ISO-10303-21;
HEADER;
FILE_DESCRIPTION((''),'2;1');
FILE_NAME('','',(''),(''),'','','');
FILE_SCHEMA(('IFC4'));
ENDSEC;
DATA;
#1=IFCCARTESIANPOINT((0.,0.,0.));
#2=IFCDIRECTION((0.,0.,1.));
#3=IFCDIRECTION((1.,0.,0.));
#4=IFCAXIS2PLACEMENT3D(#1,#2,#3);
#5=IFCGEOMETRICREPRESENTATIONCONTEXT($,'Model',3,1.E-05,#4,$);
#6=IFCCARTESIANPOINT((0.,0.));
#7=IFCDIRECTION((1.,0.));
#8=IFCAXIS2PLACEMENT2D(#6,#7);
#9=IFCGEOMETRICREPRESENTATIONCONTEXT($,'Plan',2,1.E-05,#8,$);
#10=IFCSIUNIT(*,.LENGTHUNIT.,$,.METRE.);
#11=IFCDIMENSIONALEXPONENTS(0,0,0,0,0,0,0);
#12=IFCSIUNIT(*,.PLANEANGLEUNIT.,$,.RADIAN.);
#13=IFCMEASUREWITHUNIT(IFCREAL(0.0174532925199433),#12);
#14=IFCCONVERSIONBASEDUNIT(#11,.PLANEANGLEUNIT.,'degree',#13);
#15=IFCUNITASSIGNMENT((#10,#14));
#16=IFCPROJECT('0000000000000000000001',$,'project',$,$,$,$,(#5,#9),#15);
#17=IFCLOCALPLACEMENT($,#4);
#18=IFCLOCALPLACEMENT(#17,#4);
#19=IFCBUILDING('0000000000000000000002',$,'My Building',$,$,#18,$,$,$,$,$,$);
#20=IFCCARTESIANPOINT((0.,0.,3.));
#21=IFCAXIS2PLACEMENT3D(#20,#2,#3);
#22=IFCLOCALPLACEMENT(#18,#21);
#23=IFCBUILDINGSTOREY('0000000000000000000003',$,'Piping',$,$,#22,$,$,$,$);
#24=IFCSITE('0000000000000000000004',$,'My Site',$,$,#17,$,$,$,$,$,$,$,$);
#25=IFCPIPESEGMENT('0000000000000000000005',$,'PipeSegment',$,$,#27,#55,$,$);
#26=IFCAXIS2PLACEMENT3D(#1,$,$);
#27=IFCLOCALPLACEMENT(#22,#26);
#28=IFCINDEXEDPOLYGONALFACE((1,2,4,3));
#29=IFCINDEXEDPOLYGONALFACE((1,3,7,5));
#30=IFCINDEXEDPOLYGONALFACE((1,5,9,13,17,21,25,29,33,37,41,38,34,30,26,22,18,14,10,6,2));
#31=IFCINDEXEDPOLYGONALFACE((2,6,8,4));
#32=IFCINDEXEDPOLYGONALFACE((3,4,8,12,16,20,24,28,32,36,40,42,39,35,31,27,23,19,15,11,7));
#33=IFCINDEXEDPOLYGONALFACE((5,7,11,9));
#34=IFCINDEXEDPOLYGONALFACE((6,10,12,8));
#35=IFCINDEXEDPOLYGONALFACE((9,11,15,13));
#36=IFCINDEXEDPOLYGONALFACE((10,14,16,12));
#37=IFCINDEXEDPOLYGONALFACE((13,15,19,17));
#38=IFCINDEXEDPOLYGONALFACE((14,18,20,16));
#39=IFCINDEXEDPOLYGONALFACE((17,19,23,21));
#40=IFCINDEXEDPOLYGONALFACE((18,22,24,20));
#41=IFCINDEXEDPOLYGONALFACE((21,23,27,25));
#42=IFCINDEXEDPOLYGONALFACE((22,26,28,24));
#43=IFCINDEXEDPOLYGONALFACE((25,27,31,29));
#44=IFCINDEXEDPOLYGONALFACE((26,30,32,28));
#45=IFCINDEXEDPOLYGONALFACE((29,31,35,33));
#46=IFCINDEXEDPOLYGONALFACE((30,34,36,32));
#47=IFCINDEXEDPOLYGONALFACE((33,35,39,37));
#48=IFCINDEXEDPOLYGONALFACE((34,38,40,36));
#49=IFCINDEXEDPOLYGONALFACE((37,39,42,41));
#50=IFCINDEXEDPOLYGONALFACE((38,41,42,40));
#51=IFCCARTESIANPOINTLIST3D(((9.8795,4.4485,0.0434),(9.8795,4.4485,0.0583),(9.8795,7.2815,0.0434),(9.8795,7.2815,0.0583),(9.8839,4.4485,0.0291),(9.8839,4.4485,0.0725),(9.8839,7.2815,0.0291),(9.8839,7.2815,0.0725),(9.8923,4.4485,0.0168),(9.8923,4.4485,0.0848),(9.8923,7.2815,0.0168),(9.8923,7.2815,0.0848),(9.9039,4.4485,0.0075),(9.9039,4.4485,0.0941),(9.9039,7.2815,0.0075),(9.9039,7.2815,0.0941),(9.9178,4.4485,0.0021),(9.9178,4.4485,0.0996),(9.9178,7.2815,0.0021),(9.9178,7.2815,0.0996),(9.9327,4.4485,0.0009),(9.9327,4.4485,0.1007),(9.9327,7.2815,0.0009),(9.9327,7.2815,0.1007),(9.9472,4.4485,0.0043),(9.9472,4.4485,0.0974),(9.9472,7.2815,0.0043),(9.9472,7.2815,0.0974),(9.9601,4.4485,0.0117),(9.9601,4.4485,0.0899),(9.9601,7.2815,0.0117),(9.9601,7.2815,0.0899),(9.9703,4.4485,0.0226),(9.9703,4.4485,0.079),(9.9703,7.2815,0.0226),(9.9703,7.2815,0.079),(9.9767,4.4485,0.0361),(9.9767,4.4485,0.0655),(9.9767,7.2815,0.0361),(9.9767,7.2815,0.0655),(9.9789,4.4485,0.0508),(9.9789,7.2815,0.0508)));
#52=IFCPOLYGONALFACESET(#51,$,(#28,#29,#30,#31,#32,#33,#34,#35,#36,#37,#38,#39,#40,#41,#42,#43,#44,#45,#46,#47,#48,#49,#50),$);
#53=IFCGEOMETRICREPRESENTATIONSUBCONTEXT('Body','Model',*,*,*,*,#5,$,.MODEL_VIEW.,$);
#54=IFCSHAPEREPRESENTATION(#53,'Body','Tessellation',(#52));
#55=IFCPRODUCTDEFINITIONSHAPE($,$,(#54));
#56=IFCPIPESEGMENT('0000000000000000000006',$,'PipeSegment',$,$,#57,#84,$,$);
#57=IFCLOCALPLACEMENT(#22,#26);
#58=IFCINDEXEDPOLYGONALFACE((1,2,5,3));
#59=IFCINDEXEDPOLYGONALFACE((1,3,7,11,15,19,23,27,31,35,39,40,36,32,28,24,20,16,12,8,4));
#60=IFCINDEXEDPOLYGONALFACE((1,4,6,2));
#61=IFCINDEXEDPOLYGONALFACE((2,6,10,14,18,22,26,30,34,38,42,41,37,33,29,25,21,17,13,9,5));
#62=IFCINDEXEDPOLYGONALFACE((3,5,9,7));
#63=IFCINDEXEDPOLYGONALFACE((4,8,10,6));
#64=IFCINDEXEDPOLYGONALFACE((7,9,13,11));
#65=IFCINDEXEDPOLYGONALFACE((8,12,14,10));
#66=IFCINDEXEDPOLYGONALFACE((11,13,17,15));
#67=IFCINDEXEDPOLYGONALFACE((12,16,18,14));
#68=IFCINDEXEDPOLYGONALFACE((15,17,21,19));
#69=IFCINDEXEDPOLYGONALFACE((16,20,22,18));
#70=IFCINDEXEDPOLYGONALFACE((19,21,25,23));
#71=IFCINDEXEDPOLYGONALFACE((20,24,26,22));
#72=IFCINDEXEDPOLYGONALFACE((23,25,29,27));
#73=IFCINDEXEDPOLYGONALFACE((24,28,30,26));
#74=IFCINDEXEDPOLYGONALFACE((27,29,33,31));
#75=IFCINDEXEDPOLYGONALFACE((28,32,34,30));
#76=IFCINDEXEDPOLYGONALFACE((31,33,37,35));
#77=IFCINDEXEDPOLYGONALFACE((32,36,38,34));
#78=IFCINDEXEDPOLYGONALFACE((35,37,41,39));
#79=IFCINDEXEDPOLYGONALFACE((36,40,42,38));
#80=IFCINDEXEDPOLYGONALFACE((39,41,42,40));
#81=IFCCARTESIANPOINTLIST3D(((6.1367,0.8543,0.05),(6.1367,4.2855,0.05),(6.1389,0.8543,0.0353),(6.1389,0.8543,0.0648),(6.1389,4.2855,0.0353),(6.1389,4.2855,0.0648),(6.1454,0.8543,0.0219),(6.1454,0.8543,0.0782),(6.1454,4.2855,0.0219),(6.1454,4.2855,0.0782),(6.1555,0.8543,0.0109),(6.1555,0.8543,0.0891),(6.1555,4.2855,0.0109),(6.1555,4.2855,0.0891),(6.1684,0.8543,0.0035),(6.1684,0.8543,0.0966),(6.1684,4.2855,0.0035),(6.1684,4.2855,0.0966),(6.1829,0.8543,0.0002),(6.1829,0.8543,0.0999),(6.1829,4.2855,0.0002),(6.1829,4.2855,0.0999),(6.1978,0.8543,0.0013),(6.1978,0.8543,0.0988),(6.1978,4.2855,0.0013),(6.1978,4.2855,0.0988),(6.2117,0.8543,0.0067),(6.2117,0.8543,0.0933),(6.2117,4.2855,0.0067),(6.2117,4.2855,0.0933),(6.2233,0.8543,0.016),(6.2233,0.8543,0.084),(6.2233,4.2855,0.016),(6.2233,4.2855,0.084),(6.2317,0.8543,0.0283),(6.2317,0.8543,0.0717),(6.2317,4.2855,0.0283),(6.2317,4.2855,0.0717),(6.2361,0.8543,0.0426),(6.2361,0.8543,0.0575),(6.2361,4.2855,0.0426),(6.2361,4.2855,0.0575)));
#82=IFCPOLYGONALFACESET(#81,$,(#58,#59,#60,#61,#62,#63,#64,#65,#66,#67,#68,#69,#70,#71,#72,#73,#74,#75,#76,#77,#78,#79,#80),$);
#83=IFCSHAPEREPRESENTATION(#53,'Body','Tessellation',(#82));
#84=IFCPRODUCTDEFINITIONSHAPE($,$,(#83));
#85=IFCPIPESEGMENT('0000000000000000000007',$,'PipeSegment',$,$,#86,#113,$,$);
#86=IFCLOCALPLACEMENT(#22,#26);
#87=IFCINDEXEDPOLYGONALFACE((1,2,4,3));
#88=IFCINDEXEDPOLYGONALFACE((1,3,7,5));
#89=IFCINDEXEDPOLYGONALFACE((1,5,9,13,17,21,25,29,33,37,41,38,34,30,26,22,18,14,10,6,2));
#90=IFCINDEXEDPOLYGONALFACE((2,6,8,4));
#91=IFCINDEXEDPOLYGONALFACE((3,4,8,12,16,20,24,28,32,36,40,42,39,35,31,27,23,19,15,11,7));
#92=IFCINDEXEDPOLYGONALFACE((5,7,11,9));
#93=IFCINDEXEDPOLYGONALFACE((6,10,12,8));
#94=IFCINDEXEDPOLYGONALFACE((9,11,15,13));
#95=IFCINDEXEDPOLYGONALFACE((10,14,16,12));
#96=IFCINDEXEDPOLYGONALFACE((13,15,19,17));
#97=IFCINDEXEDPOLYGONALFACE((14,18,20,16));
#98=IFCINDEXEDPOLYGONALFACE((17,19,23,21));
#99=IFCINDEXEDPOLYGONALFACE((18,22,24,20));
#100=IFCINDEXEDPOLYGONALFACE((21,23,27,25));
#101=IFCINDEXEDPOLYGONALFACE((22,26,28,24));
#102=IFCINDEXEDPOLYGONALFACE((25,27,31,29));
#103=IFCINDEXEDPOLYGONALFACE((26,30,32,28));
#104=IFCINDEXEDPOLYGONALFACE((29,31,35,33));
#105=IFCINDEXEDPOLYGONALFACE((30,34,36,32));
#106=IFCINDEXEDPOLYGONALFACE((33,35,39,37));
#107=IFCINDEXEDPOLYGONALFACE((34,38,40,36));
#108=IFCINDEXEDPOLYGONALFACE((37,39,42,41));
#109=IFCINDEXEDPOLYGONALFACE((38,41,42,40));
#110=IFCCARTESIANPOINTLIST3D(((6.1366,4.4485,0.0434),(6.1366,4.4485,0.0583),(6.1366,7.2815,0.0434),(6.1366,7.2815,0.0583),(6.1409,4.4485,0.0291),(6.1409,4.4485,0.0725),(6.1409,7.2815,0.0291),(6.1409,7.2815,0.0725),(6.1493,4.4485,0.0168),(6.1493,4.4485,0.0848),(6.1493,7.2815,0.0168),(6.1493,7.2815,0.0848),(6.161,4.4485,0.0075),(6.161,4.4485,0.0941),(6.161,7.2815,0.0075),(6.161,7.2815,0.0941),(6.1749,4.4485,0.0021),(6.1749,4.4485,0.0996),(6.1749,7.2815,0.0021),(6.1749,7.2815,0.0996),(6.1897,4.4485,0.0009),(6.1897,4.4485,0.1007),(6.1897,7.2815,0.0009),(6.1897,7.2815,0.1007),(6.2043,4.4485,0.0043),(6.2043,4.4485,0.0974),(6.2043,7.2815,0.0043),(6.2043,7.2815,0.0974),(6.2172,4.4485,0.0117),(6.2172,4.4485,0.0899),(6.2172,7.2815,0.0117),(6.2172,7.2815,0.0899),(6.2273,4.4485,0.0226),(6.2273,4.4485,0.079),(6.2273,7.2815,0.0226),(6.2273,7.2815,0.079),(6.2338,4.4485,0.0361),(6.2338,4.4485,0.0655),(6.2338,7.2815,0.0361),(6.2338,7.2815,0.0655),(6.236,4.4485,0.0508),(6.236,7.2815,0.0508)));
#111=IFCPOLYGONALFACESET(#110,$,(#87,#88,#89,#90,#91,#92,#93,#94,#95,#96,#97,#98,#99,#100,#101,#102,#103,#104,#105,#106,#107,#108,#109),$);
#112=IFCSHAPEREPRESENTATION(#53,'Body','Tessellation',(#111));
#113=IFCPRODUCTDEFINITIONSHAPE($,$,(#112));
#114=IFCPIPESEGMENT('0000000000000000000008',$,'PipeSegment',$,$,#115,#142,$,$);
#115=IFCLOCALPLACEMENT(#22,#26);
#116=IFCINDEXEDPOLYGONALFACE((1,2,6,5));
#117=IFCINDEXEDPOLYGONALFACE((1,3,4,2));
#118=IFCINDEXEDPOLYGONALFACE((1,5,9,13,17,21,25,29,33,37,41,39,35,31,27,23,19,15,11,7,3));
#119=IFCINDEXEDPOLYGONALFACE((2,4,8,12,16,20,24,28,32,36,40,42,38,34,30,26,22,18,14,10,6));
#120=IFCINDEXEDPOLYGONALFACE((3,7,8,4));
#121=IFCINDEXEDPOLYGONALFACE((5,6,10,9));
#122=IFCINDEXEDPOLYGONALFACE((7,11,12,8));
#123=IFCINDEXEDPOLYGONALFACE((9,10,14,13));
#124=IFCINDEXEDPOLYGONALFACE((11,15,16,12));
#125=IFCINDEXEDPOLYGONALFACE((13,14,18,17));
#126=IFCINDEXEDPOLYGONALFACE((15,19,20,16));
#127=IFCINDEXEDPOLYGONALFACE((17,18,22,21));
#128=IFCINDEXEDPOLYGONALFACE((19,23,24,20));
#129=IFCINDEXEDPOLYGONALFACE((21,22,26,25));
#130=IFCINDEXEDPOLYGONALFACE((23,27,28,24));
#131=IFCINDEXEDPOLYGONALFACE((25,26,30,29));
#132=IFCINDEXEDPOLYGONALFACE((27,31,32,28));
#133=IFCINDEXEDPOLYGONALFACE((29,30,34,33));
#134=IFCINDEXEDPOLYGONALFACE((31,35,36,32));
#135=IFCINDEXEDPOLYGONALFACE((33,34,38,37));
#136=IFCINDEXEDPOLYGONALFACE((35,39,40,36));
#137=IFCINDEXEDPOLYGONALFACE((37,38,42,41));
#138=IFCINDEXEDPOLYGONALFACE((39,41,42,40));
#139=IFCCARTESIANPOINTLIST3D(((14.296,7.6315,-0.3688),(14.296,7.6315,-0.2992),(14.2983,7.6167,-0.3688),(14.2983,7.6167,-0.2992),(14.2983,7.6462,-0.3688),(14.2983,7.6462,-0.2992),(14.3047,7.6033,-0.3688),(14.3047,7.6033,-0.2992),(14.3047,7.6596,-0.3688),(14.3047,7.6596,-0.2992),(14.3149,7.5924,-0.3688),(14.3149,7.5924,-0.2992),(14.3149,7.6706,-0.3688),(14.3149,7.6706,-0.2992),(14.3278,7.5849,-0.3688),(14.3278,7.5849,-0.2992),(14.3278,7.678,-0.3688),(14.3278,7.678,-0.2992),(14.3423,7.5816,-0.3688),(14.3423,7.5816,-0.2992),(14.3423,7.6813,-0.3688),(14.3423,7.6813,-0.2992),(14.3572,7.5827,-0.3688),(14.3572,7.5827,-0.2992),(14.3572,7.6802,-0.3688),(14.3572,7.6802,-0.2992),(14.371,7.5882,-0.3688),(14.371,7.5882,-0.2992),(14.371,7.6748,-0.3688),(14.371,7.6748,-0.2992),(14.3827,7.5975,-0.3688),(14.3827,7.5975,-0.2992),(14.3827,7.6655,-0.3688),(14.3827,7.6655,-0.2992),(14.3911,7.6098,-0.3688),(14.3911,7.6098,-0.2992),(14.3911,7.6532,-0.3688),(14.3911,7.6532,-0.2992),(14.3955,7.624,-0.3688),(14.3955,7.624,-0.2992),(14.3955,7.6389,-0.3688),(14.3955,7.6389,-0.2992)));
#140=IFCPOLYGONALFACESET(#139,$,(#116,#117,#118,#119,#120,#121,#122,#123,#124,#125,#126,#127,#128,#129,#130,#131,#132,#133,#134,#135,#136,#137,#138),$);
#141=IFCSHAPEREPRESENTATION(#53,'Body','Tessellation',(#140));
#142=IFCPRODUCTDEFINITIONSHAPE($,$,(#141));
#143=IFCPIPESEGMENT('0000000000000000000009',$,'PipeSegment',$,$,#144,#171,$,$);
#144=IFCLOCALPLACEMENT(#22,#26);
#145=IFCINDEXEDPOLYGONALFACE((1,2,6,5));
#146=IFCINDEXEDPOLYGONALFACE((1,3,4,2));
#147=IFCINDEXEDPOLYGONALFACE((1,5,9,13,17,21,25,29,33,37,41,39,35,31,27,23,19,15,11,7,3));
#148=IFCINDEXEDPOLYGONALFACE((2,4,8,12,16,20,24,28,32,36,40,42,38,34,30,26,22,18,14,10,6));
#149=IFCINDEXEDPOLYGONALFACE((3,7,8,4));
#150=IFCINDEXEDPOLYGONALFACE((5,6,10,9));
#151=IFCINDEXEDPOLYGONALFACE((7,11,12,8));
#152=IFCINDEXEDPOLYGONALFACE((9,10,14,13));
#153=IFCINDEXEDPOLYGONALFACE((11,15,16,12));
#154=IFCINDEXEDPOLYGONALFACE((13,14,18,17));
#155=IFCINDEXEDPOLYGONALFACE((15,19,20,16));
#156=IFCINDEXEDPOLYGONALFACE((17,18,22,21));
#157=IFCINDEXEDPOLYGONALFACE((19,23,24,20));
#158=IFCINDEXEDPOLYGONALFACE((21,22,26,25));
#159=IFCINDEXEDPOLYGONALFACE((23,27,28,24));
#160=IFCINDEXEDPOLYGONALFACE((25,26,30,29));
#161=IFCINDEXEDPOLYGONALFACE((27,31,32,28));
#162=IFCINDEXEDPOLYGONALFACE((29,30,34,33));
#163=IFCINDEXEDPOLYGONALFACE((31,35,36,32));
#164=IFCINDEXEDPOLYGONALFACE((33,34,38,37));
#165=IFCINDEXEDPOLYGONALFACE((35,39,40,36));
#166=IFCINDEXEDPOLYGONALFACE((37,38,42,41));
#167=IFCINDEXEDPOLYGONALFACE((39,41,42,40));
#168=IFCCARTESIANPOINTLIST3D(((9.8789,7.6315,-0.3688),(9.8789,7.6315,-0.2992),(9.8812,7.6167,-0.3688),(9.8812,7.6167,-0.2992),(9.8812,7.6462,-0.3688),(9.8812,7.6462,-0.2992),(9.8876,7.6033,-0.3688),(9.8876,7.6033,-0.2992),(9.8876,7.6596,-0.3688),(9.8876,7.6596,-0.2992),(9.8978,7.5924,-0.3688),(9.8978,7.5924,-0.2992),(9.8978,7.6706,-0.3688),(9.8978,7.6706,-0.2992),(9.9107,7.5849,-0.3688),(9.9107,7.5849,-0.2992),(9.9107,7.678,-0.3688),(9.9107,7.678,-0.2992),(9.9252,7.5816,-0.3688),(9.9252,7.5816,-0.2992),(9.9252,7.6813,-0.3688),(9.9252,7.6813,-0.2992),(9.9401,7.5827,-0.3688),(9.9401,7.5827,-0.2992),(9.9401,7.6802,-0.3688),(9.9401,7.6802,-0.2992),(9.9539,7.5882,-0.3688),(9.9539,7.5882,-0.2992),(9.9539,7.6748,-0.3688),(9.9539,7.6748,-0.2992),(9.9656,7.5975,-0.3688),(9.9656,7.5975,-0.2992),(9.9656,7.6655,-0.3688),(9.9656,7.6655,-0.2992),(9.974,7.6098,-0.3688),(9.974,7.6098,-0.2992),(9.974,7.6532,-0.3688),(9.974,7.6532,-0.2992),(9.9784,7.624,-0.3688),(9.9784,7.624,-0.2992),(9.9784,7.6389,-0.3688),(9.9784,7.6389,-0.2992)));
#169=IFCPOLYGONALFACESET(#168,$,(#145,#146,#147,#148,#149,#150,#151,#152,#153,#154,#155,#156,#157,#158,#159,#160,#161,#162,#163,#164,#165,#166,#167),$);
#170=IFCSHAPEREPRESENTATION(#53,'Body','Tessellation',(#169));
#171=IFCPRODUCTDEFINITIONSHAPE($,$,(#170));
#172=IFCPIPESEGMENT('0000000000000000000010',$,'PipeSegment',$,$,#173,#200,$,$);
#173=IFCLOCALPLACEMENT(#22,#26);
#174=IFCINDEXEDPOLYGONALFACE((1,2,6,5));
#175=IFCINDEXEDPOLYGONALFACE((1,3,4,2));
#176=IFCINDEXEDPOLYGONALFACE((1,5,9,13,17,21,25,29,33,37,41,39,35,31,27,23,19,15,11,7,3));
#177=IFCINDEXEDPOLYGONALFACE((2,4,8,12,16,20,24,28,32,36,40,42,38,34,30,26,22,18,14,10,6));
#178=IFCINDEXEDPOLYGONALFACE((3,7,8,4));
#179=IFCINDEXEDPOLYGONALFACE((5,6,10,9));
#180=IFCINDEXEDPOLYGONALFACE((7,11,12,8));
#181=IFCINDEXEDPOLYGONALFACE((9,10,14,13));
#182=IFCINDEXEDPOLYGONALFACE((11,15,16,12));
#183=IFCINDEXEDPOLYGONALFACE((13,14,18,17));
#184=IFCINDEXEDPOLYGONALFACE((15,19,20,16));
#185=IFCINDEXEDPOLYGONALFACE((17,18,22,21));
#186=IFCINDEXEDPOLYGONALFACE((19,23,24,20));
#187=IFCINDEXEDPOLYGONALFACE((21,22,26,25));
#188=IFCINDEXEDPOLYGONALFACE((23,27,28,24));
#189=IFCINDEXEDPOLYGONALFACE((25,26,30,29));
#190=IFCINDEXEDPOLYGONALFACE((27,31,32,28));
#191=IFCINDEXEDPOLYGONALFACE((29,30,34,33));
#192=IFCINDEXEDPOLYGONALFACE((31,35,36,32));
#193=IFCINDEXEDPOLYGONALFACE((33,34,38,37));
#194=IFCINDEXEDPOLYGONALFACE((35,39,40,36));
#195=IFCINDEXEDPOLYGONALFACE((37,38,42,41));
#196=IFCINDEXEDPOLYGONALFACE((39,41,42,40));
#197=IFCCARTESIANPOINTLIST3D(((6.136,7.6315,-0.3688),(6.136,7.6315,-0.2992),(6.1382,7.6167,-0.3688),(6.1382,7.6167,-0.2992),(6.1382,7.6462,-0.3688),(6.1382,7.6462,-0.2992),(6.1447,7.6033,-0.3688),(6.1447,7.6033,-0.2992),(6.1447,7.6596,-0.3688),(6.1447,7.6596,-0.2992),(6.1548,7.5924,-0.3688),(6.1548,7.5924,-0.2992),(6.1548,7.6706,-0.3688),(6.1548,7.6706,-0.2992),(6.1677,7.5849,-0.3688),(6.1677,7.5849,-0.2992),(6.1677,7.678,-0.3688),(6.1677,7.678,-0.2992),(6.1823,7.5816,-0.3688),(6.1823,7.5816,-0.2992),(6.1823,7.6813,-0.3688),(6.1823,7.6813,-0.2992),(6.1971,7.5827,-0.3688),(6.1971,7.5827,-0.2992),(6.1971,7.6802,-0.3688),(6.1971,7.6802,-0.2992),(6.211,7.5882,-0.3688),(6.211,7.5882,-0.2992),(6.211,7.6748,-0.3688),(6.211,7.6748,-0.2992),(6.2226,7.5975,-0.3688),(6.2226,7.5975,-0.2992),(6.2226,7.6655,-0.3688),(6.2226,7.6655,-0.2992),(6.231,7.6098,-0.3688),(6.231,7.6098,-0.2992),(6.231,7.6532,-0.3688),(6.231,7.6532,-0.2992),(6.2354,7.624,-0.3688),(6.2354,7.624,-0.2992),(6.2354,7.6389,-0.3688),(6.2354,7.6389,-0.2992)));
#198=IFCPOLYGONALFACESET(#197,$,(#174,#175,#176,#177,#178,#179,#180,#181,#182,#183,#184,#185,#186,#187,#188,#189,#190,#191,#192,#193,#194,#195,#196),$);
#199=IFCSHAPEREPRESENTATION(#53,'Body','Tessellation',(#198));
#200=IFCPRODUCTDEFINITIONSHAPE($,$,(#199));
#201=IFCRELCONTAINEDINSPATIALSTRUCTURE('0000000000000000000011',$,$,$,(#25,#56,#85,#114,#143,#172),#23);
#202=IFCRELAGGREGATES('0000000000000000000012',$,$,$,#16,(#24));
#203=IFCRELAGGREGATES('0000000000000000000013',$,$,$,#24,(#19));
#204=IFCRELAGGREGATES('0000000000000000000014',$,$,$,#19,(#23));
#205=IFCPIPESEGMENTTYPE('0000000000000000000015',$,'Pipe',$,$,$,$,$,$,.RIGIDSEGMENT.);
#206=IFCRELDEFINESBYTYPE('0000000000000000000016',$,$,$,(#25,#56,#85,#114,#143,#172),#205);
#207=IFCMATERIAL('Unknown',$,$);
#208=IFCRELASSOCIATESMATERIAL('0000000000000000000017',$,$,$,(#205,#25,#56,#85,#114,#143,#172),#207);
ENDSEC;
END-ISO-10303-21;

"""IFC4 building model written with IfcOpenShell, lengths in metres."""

from ifc_helpers import new_model, entity, si_unit, converted_unit, frame, origin_with_axes, origin_2d_with_axis, place, context, subcontext, project, spatial, circle, extrude, material, material_profile, profile_set, profile_usage, type_object, element, save


model = new_model("IFC4")

# Units and contexts
model_context = context("Model", 3, precision=1e-05, world=origin_with_axes())
plan_context = context("Plan", 2, precision=1e-05, world=origin_2d_with_axis())
body_context = subcontext(model_context, "Body", "Model", "MODEL_VIEW")
ifc_project = project(units=[si_unit("LENGTHUNIT", "METRE"), converted_unit("PLANEANGLEUNIT", "degree", entity("IfcReal", 0.0174532925199433), si_unit("PLANEANGLEUNIT", "RADIAN"), dimensions=[0, 0, 0, 0, 0, 0, 0])], contexts=[model_context, plan_context])

# Site, building, storey
site_placement = place(None, origin_with_axes())
site = spatial("IfcSite", under=ifc_project, at=site_placement, Name="My Site")
building_placement = place(site_placement, origin_with_axes())
building = spatial("IfcBuilding", under=site, at=building_placement, Name="My Building")
storey_placement = place(building_placement, frame((0.0, 0.0, 3.0), z_axis=(0.0, 0.0, 1.0), x_axis=(1.0, 0.0, 0.0)))
storey = spatial("IfcBuildingStorey", under=building, at=storey_placement, Name="Piping")

# Pipe segments
ifc_material = material(Name="Unknown")
ifc_material_profile_1 = material_profile(ifc_material, circle(Radius=0.05))
ifc_profile_set_1 = profile_set([ifc_material_profile_1])
pipe_segment_type = type_object("IfcPipeSegmentType", Name="Pipe", PredefinedType="RIGIDSEGMENT", material=ifc_profile_set_1)
ifc_profile_usage_1 = profile_usage(ifc_profile_set_1, cardinal=5)
pipe_segment_1_placement = place(storey_placement, frame((9.9289, 4.4485, 0.0508), z_axis=(0.0, 1.0, 0.0), x_axis=(1.0, 0.0, 0.0)))
element("IfcPipeSegment", 1, at=pipe_segment_1_placement, inside=storey, type_object=pipe_segment_type, material=ifc_profile_usage_1, Name="PipeSegment", context=body_context, shape_type="SweptSolid", body=[
    extrude(circle(Radius=0.05), origin_with_axes(), (0.0, 0.0, 1.0), 2.833),
])
ifc_profile_usage_2 = profile_usage(ifc_profile_set_1, cardinal=5)
pipe_segment_2_placement = place(storey_placement, frame((6.1867, 0.8543, 0.05), z_axis=(0.0, 1.0, 0.0), x_axis=(-1.0, 0.0, 0.0)))
element("IfcPipeSegment", 2, at=pipe_segment_2_placement, inside=storey, type_object=pipe_segment_type, material=ifc_profile_usage_2, Name="PipeSegment", context=body_context, shape_type="SweptSolid", body=[
    extrude(circle(Radius=0.05), origin_with_axes(), (0.0, 0.0, 1.0), 3.4313),
])
ifc_profile_usage_3 = profile_usage(ifc_profile_set_1, cardinal=5)
pipe_segment_3_placement = place(storey_placement, frame((6.186, 4.4485, 0.0508), z_axis=(0.0, 1.0, 0.0), x_axis=(1.0, 0.0, 0.0)))
element("IfcPipeSegment", 3, at=pipe_segment_3_placement, inside=storey, type_object=pipe_segment_type, material=ifc_profile_usage_3, Name="PipeSegment", context=body_context, shape_type="SweptSolid", body=[
    extrude(circle(Radius=0.05), origin_with_axes(), (0.0, 0.0, 1.0), 2.833),
])
ifc_profile_usage_4 = profile_usage(ifc_profile_set_1, cardinal=16)
pipe_segment_4_placement = place(storey_placement, frame((14.346, 7.6315, -0.2992), z_axis=(0.0, 0.0, -1.0), x_axis=(-1.0, 0.0, 0.0)))
element("IfcPipeSegment", 4, at=pipe_segment_4_placement, inside=storey, type_object=pipe_segment_type, material=ifc_profile_usage_4, Name="PipeSegment", context=body_context, shape_type="SweptSolid", body=[
    extrude(circle(Radius=0.05), origin_with_axes(), (0.0, 0.0, 1.0), 0.0696),
])
ifc_profile_usage_5 = profile_usage(ifc_profile_set_1, cardinal=16)
pipe_segment_5_placement = place(storey_placement, frame((9.9289, 7.6315, -0.2992), z_axis=(0.0, 0.0, -1.0), x_axis=(-1.0, 0.0, 0.0)))
element("IfcPipeSegment", 5, at=pipe_segment_5_placement, inside=storey, type_object=pipe_segment_type, material=ifc_profile_usage_5, Name="PipeSegment", context=body_context, shape_type="SweptSolid", body=[
    extrude(circle(Radius=0.05), origin_with_axes(), (0.0, 0.0, 1.0), 0.0696),
])
ifc_profile_usage_6 = profile_usage(ifc_profile_set_1, cardinal=16)
pipe_segment_6_placement = place(storey_placement, frame((6.186, 7.6315, -0.2992), z_axis=(0.0, 0.0, -1.0), x_axis=(-1.0, 0.0, 0.0)))
element("IfcPipeSegment", 6, at=pipe_segment_6_placement, inside=storey, type_object=pipe_segment_type, material=ifc_profile_usage_6, Name="PipeSegment", context=body_context, shape_type="SweptSolid", body=[
    extrude(circle(Radius=0.05), origin_with_axes(), (0.0, 0.0, 1.0), 0.0696),
])

save(model, "model.ifc")
